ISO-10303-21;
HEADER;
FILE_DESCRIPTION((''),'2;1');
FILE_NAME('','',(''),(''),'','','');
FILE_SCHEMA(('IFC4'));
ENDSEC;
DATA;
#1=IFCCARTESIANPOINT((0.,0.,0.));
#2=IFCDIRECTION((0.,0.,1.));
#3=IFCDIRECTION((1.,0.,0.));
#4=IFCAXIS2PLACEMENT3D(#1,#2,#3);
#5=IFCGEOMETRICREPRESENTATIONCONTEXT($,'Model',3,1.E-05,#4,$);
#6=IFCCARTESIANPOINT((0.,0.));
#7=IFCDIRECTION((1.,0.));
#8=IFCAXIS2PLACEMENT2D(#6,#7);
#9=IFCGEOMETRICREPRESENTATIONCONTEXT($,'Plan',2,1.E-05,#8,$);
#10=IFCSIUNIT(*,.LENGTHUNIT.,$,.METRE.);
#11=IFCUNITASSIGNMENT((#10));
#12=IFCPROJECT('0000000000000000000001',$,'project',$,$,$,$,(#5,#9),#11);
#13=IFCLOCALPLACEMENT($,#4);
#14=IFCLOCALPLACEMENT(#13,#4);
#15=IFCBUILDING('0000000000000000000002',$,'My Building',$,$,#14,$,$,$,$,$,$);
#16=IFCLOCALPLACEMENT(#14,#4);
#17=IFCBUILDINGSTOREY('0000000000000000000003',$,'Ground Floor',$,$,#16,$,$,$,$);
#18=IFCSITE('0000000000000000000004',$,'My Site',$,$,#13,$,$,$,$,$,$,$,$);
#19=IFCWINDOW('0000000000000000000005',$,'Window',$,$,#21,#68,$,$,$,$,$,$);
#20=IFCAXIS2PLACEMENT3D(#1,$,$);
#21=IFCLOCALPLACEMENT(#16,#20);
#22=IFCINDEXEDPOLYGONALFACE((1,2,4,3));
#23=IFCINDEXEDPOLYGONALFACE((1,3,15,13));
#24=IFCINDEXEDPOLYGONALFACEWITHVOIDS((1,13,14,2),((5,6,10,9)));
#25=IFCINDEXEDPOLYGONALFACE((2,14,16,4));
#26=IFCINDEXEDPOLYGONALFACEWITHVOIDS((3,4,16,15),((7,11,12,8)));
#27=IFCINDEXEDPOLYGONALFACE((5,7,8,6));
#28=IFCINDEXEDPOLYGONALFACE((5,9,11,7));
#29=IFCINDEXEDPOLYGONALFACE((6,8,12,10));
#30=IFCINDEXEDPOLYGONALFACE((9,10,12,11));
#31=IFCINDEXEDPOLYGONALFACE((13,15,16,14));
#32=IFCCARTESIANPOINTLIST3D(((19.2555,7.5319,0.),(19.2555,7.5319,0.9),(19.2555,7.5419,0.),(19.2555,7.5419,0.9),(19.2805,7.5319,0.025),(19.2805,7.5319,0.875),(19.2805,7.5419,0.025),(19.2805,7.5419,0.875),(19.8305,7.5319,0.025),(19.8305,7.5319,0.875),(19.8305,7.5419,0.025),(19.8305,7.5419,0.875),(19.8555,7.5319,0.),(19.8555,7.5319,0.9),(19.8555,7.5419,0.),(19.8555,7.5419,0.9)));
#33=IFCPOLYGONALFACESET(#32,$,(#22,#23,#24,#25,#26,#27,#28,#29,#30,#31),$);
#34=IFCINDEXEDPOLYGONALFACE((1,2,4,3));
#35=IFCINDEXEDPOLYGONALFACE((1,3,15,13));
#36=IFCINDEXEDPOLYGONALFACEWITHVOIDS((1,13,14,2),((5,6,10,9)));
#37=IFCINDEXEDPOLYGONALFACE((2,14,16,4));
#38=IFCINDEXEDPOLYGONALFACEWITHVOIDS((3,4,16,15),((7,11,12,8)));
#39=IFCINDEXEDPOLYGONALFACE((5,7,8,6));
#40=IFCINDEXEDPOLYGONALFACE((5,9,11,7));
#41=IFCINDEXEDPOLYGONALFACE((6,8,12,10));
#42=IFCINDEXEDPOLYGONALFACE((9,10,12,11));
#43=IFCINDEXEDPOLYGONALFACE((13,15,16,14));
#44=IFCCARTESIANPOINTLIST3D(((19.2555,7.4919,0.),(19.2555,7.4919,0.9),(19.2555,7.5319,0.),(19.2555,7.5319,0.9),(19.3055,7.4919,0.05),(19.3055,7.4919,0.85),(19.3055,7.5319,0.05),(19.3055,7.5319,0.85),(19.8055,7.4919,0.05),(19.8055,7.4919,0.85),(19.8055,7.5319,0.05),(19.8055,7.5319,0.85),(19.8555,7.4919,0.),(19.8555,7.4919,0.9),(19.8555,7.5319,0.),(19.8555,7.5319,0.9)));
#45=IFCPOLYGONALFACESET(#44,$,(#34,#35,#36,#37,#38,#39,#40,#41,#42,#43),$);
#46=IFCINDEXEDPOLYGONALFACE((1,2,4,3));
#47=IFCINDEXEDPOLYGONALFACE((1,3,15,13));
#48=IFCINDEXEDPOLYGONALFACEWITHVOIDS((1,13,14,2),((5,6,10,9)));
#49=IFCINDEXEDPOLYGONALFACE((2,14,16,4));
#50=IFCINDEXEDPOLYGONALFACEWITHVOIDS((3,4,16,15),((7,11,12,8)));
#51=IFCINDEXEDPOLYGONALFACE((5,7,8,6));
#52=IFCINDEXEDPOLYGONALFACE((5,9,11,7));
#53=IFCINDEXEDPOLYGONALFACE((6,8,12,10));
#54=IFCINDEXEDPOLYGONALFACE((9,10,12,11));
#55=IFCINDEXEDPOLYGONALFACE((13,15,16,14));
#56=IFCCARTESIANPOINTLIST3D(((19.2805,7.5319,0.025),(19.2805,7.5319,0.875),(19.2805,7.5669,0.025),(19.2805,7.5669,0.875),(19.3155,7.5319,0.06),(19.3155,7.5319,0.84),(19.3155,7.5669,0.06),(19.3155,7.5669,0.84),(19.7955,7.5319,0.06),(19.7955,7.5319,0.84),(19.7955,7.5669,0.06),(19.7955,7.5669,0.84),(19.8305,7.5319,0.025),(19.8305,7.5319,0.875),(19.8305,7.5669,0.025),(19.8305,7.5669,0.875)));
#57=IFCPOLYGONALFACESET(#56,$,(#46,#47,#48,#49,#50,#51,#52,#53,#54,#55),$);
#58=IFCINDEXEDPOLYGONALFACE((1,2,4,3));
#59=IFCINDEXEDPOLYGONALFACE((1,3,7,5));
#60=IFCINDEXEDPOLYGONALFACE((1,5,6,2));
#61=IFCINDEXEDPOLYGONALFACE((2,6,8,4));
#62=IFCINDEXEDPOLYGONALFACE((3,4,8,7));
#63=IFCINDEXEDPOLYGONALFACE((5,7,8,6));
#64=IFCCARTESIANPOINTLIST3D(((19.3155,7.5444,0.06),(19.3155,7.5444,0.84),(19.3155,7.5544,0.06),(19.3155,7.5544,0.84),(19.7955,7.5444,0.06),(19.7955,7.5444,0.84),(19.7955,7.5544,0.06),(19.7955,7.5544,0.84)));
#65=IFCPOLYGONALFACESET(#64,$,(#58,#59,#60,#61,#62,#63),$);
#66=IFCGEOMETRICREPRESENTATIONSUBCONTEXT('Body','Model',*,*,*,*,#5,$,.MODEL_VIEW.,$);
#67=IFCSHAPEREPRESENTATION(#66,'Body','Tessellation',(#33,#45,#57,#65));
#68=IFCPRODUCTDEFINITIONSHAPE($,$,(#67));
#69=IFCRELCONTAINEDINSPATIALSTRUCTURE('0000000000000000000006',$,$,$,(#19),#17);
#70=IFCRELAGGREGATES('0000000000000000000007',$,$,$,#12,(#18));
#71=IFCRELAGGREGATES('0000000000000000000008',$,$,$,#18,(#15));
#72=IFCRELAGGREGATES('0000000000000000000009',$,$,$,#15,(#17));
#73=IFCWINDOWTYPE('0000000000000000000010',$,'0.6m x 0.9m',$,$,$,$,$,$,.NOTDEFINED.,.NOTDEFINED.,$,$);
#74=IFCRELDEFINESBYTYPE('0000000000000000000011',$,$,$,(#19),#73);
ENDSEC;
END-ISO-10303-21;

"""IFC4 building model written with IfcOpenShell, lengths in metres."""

from ifc_helpers import new_model, entity, si_unit, frame, origin_with_axes, origin_2d_with_axis, place, context, subcontext, project, spatial, line, indexed_curve, outline, extrude, shape, source, transform, mapped, type_object, type_shapes, element, save


model = new_model("IFC4")

# Units and contexts
model_context = context("Model", 3, precision=1e-05, world=origin_with_axes())
plan_context = context("Plan", 2, precision=1e-05, world=origin_2d_with_axis())
body_context_1 = subcontext(model_context, "Body", "Model", "MODEL_VIEW")
body_context_2 = subcontext(plan_context, "Body", "Plan", "PLAN_VIEW")
ifc_project = project(units=[si_unit("LENGTHUNIT", "METRE")], contexts=[model_context, plan_context])

# Site, building, storey
site_placement = place(None, origin_with_axes())
site = spatial("IfcSite", under=ifc_project, at=site_placement, Name="My Site")
building_placement = place(site_placement, origin_with_axes())
building = spatial("IfcBuilding", under=site, at=building_placement, Name="My Building")
storey_placement = place(building_placement, origin_with_axes())
storey = spatial("IfcBuildingStorey", under=building, at=storey_placement, Name="Ground Floor")

# Window
window_type = type_object("IfcWindowType", Name="0.6m x 0.9m", PartitioningType="NOTDEFINED", PredefinedType="NOTDEFINED")
shared_shape_1 = source(origin_with_axes(), body_context_1, "Body", "SweptSolid", [
    extrude(outline(indexed_curve([(0.0, 0.0), (0.6, 0.0), (0.6, 0.9), (0.0, 0.9)], segments=[line(1, 2, 3, 4, 1)]), holes=[indexed_curve([(0.025, 0.025), (0.575, 0.025), (0.575, 0.875), (0.025, 0.875)], segments=[line(1, 2, 3, 4, 1)])]), frame((0.0, 0.09, 0.0), z_axis=(0.0, -1.0, 0.0), x_axis=(1.0, 0.0, 0.0)), (0.0, 0.0, -1.0), 0.01),
    extrude(outline(indexed_curve([(0.0, 0.0), (0.6, 0.0), (0.6, 0.9), (0.0, 0.9)], segments=[line(1, 2, 3, 4, 1)]), holes=[indexed_curve([(0.05, 0.05), (0.55, 0.05), (0.55, 0.85), (0.05, 0.85)], segments=[line(1, 2, 3, 4, 1)])]), frame((0.0, 0.05, 0.0), z_axis=(0.0, -1.0, 0.0), x_axis=(1.0, 0.0, 0.0)), (0.0, 0.0, -1.0), 0.04),
    extrude(outline(indexed_curve([(0.0, 0.0), (0.55, 0.0), (0.55, 0.85), (0.0, 0.85)], segments=[line(1, 2, 3, 4, 1)]), holes=[indexed_curve([(0.035, 0.035), (0.515, 0.035), (0.515, 0.815), (0.035, 0.815)], segments=[line(1, 2, 3, 4, 1)])]), frame((0.025, 0.09, 0.025), z_axis=(0.0, -1.0, 0.0), x_axis=(1.0, 0.0, 0.0)), (0.0, 0.0, -1.0), 0.035),
    extrude(outline(indexed_curve([(0.035, 0.035), (0.515, 0.035), (0.515, 0.815), (0.035, 0.815)], segments=[line(1, 2, 3, 4, 1)])), frame((0.025, 0.1025, 0.025), z_axis=(0.0, -1.0, 0.0), x_axis=(1.0, 0.0, 0.0)), (0.0, 0.0, -1.0), 0.01),
])
shared_shape_2 = source(origin_with_axes(), body_context_2, "Body", "Curve2D", [
    entity("IfcIndexedPolyCurve", entity("IfcCartesianPointList2D", [[0.05, 0.05], [0.55, 0.05]])),
    entity("IfcIndexedPolyCurve", entity("IfcCartesianPointList2D", [[0.0, 0.1], [0.025, 0.1], [0.025, 0.09], [0.05, 0.09], [0.05, 0.05], [0.0, 0.05]]), [entity("IfcLineIndex", [1, 2, 3, 4, 5, 6, 1])]),
    entity("IfcIndexedPolyCurve", entity("IfcCartesianPointList2D", [[0.6, 0.1], [0.575, 0.1], [0.575, 0.09], [0.55, 0.09], [0.55, 0.05], [0.6, 0.05]]), [entity("IfcLineIndex", [1, 2, 3, 4, 5, 6, 1])]),
    entity("IfcIndexedPolyCurve", entity("IfcCartesianPointList2D", [[0.025, 0.09], [0.06, 0.09], [0.06, 0.125], [0.025, 0.125]]), [entity("IfcLineIndex", [1, 2, 3, 4, 1])]),
    entity("IfcIndexedPolyCurve", entity("IfcCartesianPointList2D", [[0.575, 0.09], [0.54, 0.09], [0.54, 0.125], [0.575, 0.125]]), [entity("IfcLineIndex", [1, 2, 3, 4, 1])]),
    entity("IfcIndexedPolyCurve", entity("IfcCartesianPointList2D", [[0.06, 0.09], [0.54, 0.09]])),
    entity("IfcIndexedPolyCurve", entity("IfcCartesianPointList2D", [[0.06, 0.125], [0.54, 0.125]])),
    entity("IfcIndexedPolyCurve", entity("IfcCartesianPointList2D", [[0.06, 0.1075], [0.54, 0.1075]])),
])
type_shapes(window_type, [shared_shape_1, shared_shape_2])
window_placement = place(storey_placement, frame((19.2555, 7.4419, 0.0), z_axis=(0.0, 0.0, 1.0), x_axis=(1.0, 0.0, 0.0)))
element("IfcWindow", 1, at=window_placement, inside=storey, type_object=window_type, Name="Window", shapes=[
    shape(body_context_1, "Body", "MappedRepresentation", [mapped(shared_shape_1, transform((0.0, 0.0, 0.0), x_axis=(1.0, 0.0, 0.0), y_axis=(0.0, 1.0, 0.0), z_axis=(0.0, 0.0, 1.0), scale=1.0))]),
    shape(body_context_2, "Body", "MappedRepresentation", [mapped(shared_shape_2, transform((0.0, 0.0, 0.0), x_axis=(1.0, 0.0, 0.0), y_axis=(0.0, 1.0, 0.0), z_axis=(0.0, 0.0, 1.0), scale=1.0))]),
])

save(model, "model.ifc")
